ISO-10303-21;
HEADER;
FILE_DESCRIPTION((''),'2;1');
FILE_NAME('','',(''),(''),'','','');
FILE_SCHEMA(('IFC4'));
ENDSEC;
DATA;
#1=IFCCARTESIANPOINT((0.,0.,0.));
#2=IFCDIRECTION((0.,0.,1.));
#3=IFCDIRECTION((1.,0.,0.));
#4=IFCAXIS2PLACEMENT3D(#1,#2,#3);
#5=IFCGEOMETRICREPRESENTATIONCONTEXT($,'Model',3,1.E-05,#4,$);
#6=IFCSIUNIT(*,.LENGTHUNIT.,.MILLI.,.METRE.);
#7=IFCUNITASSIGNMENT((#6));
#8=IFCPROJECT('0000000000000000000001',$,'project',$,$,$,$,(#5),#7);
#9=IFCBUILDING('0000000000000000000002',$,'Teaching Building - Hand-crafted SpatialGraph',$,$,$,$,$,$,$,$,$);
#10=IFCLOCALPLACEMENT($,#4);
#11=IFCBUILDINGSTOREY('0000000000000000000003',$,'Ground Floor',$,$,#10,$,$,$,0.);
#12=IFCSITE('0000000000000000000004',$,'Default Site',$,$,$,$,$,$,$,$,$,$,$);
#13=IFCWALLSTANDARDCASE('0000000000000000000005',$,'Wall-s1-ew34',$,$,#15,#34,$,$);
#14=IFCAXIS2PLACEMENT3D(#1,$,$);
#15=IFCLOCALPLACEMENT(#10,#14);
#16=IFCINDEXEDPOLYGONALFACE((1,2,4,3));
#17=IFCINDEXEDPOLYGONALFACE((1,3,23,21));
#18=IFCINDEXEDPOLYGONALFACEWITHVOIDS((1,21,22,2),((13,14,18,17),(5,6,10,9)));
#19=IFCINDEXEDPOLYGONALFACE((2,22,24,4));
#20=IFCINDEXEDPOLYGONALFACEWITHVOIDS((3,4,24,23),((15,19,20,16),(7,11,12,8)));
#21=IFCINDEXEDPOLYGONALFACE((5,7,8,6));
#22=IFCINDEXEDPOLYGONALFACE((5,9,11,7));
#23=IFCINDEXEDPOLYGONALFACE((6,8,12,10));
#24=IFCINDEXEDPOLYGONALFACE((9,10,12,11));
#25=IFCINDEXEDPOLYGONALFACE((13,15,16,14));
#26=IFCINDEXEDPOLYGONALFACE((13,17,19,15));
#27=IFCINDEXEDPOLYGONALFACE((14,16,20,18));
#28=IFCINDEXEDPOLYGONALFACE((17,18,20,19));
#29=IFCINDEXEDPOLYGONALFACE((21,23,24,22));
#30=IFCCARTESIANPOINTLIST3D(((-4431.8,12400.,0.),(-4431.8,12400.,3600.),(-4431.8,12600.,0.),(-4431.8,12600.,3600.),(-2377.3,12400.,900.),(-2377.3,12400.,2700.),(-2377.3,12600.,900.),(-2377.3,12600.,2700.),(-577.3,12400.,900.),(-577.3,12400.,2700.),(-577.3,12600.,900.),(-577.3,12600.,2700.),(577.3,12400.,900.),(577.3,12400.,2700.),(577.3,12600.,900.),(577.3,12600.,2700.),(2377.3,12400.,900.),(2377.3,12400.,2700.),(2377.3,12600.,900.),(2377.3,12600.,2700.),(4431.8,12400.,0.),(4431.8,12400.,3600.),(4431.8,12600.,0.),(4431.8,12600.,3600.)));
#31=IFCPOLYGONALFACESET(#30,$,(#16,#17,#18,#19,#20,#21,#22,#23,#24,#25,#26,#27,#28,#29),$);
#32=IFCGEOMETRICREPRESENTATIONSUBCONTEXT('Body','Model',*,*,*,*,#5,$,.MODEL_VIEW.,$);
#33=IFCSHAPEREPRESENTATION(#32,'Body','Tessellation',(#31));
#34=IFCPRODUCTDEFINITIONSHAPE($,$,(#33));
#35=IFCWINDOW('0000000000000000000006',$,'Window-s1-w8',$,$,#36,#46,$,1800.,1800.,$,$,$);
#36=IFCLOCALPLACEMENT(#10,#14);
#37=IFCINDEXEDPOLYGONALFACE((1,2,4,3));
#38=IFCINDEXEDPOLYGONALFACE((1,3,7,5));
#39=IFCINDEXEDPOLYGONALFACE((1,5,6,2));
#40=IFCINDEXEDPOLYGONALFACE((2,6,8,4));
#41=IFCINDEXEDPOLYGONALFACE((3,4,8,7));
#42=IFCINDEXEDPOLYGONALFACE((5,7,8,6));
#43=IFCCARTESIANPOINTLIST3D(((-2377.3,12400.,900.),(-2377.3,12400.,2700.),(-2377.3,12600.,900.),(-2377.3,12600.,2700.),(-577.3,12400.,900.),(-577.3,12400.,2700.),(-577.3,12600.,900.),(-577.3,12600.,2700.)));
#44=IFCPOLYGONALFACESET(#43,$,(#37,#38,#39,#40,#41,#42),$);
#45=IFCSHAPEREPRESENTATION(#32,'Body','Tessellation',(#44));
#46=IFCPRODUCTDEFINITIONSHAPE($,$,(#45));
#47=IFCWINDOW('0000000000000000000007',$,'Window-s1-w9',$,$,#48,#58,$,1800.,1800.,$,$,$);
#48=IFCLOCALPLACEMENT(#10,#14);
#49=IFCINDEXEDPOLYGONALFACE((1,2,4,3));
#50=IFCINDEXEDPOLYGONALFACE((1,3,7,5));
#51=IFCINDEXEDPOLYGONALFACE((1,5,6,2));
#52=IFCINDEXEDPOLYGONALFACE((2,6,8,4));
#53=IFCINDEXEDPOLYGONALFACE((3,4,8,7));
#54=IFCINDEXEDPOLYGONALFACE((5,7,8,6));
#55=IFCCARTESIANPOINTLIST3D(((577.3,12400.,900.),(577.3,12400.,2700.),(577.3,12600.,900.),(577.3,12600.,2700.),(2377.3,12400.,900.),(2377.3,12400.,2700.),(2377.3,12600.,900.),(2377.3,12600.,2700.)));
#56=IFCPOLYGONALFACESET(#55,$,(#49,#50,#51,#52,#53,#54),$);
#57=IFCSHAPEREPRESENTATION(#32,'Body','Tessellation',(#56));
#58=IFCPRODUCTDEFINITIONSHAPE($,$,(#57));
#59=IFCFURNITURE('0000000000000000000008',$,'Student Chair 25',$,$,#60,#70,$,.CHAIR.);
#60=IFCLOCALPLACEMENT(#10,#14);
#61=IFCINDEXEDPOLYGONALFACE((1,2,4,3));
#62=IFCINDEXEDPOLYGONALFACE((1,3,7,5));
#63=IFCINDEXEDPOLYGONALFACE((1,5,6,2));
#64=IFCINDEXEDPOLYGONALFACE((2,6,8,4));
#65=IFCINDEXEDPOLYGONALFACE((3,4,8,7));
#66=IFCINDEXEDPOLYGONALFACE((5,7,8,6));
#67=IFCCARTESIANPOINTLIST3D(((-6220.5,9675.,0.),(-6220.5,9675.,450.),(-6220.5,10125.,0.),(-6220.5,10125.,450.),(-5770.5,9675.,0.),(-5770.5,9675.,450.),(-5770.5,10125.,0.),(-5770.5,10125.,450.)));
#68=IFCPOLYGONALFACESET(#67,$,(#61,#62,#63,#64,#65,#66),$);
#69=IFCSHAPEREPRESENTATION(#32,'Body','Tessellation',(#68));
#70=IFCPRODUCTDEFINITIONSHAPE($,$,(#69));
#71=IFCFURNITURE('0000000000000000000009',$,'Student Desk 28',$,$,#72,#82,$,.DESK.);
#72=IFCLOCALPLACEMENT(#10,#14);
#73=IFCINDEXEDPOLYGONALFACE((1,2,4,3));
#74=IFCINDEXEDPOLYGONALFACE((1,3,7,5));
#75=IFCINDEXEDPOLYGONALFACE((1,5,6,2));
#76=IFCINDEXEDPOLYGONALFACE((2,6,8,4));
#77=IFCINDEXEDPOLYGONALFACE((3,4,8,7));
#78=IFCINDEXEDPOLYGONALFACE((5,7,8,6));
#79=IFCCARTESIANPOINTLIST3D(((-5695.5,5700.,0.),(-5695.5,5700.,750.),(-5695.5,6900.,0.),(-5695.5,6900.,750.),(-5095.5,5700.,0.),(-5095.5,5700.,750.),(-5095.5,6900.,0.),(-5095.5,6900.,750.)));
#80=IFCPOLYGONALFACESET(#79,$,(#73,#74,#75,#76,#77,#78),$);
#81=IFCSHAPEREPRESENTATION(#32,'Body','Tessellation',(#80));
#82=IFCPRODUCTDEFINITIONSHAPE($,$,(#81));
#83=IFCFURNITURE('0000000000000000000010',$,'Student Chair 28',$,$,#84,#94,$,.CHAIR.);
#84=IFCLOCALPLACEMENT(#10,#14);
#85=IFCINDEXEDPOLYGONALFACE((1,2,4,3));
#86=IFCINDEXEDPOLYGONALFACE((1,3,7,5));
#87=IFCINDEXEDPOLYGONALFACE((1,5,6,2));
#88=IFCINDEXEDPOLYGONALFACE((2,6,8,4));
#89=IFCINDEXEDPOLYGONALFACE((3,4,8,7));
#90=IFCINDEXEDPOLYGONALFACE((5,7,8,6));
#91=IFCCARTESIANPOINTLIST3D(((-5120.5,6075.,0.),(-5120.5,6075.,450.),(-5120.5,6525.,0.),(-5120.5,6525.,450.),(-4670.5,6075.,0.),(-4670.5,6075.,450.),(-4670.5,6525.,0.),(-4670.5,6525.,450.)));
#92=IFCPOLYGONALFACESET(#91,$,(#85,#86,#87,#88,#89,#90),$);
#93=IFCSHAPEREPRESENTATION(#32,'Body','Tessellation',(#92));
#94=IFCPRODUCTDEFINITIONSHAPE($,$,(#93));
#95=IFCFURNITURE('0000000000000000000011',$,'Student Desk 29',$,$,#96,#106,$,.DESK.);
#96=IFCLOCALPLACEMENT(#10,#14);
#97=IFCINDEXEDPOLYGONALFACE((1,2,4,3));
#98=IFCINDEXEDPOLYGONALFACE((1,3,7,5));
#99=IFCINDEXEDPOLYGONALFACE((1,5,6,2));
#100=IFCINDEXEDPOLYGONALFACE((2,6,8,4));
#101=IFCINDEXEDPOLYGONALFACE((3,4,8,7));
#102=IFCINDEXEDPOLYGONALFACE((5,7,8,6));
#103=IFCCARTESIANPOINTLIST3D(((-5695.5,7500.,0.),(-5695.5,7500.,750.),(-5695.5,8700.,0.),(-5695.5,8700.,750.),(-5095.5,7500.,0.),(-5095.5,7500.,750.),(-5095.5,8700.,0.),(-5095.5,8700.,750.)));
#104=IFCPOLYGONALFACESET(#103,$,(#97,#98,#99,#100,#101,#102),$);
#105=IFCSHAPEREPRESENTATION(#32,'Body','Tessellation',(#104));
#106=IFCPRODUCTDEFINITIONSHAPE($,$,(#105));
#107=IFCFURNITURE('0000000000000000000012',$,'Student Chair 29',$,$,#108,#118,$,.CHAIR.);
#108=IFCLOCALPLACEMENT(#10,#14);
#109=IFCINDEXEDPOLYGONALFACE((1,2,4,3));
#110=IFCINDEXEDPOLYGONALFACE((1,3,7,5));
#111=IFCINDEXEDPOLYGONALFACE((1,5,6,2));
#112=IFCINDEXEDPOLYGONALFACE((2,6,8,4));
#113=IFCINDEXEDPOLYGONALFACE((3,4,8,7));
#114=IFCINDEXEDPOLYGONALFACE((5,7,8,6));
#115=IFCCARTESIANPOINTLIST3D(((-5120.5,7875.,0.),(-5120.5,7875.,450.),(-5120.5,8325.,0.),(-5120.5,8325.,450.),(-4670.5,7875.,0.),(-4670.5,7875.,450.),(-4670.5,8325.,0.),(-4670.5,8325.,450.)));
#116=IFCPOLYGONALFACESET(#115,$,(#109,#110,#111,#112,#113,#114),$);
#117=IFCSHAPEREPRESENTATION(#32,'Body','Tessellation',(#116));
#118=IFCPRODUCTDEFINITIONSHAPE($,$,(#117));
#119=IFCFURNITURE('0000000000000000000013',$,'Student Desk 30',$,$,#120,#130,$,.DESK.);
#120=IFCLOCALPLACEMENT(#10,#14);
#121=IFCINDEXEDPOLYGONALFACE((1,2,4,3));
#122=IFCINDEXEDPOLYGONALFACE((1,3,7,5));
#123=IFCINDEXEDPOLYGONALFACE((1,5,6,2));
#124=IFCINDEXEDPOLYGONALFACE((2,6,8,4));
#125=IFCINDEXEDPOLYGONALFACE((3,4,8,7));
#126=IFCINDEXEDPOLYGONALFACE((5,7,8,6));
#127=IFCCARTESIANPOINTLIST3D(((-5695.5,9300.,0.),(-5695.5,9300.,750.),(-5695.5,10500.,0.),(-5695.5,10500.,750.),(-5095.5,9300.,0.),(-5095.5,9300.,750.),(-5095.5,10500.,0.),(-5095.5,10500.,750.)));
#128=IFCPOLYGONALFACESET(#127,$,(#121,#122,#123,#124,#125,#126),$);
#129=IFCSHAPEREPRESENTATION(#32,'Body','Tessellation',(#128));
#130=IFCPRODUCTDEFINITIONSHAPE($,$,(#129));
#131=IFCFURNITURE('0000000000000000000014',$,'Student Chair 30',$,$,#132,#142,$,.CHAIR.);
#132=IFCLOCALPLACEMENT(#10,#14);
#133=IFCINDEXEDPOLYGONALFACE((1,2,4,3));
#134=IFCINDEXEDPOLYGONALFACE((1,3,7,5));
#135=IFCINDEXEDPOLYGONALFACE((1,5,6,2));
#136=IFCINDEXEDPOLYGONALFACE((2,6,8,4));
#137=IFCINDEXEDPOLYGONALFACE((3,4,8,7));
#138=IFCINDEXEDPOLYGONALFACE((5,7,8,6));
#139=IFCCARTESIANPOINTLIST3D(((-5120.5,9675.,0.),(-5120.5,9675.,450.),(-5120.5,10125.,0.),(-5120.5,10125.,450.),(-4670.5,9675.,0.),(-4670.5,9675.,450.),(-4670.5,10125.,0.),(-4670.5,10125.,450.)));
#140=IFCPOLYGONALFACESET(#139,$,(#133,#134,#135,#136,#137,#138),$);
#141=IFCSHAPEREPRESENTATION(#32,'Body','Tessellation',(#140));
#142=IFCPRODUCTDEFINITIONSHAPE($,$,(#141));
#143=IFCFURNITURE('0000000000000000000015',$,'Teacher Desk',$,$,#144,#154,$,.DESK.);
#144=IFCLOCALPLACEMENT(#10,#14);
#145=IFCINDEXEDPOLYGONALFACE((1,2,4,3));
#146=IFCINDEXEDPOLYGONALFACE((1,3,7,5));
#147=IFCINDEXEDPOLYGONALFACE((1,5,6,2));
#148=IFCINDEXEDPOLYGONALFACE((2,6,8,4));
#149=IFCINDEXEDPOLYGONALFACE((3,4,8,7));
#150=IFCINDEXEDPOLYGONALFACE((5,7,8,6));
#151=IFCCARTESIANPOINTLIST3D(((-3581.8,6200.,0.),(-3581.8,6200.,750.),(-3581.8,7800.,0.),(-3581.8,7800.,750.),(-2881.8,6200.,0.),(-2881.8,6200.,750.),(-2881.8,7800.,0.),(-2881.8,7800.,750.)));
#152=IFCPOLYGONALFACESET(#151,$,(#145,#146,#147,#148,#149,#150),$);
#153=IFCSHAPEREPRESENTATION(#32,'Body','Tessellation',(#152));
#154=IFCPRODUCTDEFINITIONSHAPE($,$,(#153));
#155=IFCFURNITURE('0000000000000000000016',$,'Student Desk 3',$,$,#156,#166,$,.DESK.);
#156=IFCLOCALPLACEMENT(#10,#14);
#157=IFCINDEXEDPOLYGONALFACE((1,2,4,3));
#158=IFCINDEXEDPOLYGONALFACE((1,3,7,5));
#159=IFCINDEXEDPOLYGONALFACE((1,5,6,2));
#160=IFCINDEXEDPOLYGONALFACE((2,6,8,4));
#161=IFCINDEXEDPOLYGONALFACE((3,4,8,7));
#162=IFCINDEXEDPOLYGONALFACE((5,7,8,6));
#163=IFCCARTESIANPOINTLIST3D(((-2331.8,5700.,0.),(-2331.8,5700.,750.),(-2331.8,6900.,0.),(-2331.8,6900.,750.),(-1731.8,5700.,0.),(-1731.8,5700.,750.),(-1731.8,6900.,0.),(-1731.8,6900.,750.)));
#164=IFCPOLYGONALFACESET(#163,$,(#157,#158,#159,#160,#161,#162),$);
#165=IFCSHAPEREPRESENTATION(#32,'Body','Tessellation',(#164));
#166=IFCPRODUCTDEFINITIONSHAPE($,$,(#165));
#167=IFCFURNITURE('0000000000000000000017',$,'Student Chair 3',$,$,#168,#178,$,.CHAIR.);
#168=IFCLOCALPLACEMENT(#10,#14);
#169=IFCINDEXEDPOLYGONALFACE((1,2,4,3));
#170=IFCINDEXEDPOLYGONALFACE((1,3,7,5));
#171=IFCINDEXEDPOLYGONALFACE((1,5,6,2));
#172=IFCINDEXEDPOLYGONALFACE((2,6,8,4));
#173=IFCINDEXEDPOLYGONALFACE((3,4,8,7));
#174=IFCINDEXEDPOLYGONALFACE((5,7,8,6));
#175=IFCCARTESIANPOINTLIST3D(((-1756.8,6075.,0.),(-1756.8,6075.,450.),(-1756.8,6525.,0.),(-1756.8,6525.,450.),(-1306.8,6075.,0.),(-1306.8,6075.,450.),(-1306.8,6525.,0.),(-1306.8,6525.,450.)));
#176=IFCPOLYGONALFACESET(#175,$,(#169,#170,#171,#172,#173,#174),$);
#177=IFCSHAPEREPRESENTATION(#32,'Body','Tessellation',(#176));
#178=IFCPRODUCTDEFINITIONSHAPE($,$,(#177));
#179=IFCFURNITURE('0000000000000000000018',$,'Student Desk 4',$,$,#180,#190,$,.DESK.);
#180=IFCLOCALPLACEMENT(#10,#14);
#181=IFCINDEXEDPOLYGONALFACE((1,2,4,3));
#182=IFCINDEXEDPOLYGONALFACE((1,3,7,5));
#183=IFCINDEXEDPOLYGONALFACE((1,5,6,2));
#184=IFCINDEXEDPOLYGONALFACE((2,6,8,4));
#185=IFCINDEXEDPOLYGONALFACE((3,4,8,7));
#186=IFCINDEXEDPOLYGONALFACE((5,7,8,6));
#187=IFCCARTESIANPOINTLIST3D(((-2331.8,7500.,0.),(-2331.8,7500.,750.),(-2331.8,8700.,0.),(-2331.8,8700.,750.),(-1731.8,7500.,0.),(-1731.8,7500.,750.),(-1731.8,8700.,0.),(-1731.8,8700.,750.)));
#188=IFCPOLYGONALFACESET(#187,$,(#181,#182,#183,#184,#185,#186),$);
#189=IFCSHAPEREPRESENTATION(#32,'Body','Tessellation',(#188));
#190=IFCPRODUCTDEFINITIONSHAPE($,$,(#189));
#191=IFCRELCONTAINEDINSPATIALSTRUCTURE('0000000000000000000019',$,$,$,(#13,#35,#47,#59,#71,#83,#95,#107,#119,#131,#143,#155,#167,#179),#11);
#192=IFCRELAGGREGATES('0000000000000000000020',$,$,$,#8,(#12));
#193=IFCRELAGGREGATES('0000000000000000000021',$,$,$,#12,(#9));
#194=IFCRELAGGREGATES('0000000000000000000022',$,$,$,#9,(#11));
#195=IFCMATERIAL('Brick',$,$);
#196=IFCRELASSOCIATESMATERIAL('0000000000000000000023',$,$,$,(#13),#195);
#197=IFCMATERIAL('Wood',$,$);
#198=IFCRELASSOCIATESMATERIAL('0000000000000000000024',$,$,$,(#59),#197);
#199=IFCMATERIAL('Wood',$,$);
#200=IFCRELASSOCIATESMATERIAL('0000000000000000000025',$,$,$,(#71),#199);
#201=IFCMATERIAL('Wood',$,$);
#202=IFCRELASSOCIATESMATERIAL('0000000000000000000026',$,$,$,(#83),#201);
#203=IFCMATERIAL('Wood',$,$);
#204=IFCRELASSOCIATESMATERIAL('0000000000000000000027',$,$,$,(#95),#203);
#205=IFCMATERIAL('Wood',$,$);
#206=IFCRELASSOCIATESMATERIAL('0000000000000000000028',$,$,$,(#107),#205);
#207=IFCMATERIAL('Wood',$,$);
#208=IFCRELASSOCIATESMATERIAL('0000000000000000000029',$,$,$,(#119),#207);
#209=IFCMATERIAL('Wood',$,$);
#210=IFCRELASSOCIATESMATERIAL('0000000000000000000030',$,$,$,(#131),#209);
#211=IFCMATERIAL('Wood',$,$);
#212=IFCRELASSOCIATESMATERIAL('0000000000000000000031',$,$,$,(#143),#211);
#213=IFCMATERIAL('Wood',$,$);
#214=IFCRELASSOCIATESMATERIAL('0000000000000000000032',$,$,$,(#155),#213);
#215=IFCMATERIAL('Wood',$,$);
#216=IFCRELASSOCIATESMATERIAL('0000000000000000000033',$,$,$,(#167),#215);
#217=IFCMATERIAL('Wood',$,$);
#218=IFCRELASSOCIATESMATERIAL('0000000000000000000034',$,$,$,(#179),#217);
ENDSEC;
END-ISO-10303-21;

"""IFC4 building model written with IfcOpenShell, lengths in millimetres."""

from ifc_helpers import new_model, si_unit, frame, frame_2d, origin_with_axes, origin_2d, place, context, subcontext, project, spatial, rectangle, extrude, material, element, fill, save


model = new_model("IFC4")

# Units and contexts
model_context = context("Model", 3, precision=1e-05, world=origin_with_axes())
body_context = subcontext(model_context, "Body", "Model", "MODEL_VIEW")
ifc_project = project(units=[si_unit("LENGTHUNIT", "METRE", prefix="MILLI")], contexts=[model_context])

# Site, building, storey
site = spatial("IfcSite", under=ifc_project, Name="Default Site")
building = spatial("IfcBuilding", under=site, Name="Teaching Building - Hand-crafted SpatialGraph")
storey_placement = place(None, origin_with_axes())
storey = spatial("IfcBuildingStorey", under=building, at=storey_placement, Name="Ground Floor", Elevation=0.0)

# Wall, openings, windows
ifc_material_1 = material(Name="Brick")
wall_placement = place(storey_placement, frame((-4431.8, 12500.0, 0.0), z_axis=(0.0, 0.0, 1.0), x_axis=(1.0, 0.0, 0.0)))
wall = element("IfcWallStandardCase", 1, at=wall_placement, inside=storey, material=ifc_material_1, Name="Wall-s1-ew34", context=body_context, shape_type="SweptSolid", body=[
    extrude(rectangle(XDim=8863.6, YDim=200.0, at=frame_2d((4431.8, 0.0))), origin_with_axes(), (0.0, 0.0, 1.0), 3600.0),
])
opening_1_placement = place(wall_placement, frame((2054.5, 0.0, 900.0), z_axis=(0.0, 0.0, 1.0), x_axis=(1.0, 0.0, 0.0)))
opening_1 = element("IfcOpeningElement", 2, at=opening_1_placement, cuts=wall, context=body_context, shape_type="SweptSolid", body=[
    extrude(rectangle(XDim=1800.0, YDim=400.0, at=frame_2d((900.0, 0.0))), origin_with_axes(), (0.0, 0.0, 1.0), 1800.0),
])
opening_2_placement = place(wall_placement, frame((5009.1, 0.0, 900.0), z_axis=(0.0, 0.0, 1.0), x_axis=(1.0, 0.0, 0.0)))
opening_2 = element("IfcOpeningElement", 3, at=opening_2_placement, cuts=wall, context=body_context, shape_type="SweptSolid", body=[
    extrude(rectangle(XDim=1800.0, YDim=400.0, at=frame_2d((900.0, 0.0))), origin_with_axes(), (0.0, 0.0, 1.0), 1800.0),
])
window_1_placement = place(storey_placement, frame((-2377.3, 12500.0, 900.0), z_axis=(0.0, 0.0, 1.0), x_axis=(1.0, 0.0, 0.0)))
window_1 = element("IfcWindow", 4, at=window_1_placement, inside=storey, Name="Window-s1-w8", OverallHeight=1800.0, OverallWidth=1800.0, context=body_context, shape_type="SweptSolid", body=[
    extrude(rectangle(XDim=1800.0, YDim=200.0, at=frame_2d((900.0, 0.0))), origin_with_axes(), (0.0, 0.0, 1.0), 1800.0),
])
fill(opening_1, window_1)
window_2_placement = place(storey_placement, frame((577.3, 12500.0, 900.0), z_axis=(0.0, 0.0, 1.0), x_axis=(1.0, 0.0, 0.0)))
window_2 = element("IfcWindow", 5, at=window_2_placement, inside=storey, Name="Window-s1-w9", OverallHeight=1800.0, OverallWidth=1800.0, context=body_context, shape_type="SweptSolid", body=[
    extrude(rectangle(XDim=1800.0, YDim=200.0, at=frame_2d((900.0, 0.0))), origin_with_axes(), (0.0, 0.0, 1.0), 1800.0),
])
fill(opening_2, window_2)

# Furniture
ifc_material_2 = material(Name="Wood")
furniture_1_placement = place(storey_placement, frame((-5995.5, 9900.0, 0.0), z_axis=(0.0, 0.0, 1.0), x_axis=(1.0, 0.0, 0.0)))
element("IfcFurniture", 6, at=furniture_1_placement, inside=storey, material=ifc_material_2, Name="Student Chair 25", PredefinedType="CHAIR", context=body_context, shape_type="SweptSolid", body=[
    extrude(rectangle(XDim=450.0, YDim=450.0, at=origin_2d()), origin_with_axes(), (0.0, 0.0, 1.0), 450.0),
])
ifc_material_3 = material(Name="Wood")
furniture_2_placement = place(storey_placement, frame((-5395.5, 6300.0, 0.0), z_axis=(0.0, 0.0, 1.0), x_axis=(0.0, 1.0, 0.0)))
element("IfcFurniture", 7, at=furniture_2_placement, inside=storey, material=ifc_material_3, Name="Student Desk 28", PredefinedType="DESK", context=body_context, shape_type="SweptSolid", body=[
    extrude(rectangle(XDim=1200.0, YDim=600.0, at=origin_2d()), origin_with_axes(), (0.0, 0.0, 1.0), 750.0),
])
ifc_material_4 = material(Name="Wood")
furniture_3_placement = place(storey_placement, frame((-4895.5, 6300.0, 0.0), z_axis=(0.0, 0.0, 1.0), x_axis=(1.0, 0.0, 0.0)))
element("IfcFurniture", 8, at=furniture_3_placement, inside=storey, material=ifc_material_4, Name="Student Chair 28", PredefinedType="CHAIR", context=body_context, shape_type="SweptSolid", body=[
    extrude(rectangle(XDim=450.0, YDim=450.0, at=origin_2d()), origin_with_axes(), (0.0, 0.0, 1.0), 450.0),
])
ifc_material_5 = material(Name="Wood")
furniture_4_placement = place(storey_placement, frame((-5395.5, 8100.0, 0.0), z_axis=(0.0, 0.0, 1.0), x_axis=(0.0, 1.0, 0.0)))
element("IfcFurniture", 9, at=furniture_4_placement, inside=storey, material=ifc_material_5, Name="Student Desk 29", PredefinedType="DESK", context=body_context, shape_type="SweptSolid", body=[
    extrude(rectangle(XDim=1200.0, YDim=600.0, at=origin_2d()), origin_with_axes(), (0.0, 0.0, 1.0), 750.0),
])
ifc_material_6 = material(Name="Wood")
furniture_5_placement = place(storey_placement, frame((-4895.5, 8100.0, 0.0), z_axis=(0.0, 0.0, 1.0), x_axis=(1.0, 0.0, 0.0)))
element("IfcFurniture", 10, at=furniture_5_placement, inside=storey, material=ifc_material_6, Name="Student Chair 29", PredefinedType="CHAIR", context=body_context, shape_type="SweptSolid", body=[
    extrude(rectangle(XDim=450.0, YDim=450.0, at=origin_2d()), origin_with_axes(), (0.0, 0.0, 1.0), 450.0),
])
ifc_material_7 = material(Name="Wood")
furniture_6_placement = place(storey_placement, frame((-5395.5, 9900.0, 0.0), z_axis=(0.0, 0.0, 1.0), x_axis=(0.0, 1.0, 0.0)))
element("IfcFurniture", 11, at=furniture_6_placement, inside=storey, material=ifc_material_7, Name="Student Desk 30", PredefinedType="DESK", context=body_context, shape_type="SweptSolid", body=[
    extrude(rectangle(XDim=1200.0, YDim=600.0, at=origin_2d()), origin_with_axes(), (0.0, 0.0, 1.0), 750.0),
])
ifc_material_8 = material(Name="Wood")
furniture_7_placement = place(storey_placement, frame((-4895.5, 9900.0, 0.0), z_axis=(0.0, 0.0, 1.0), x_axis=(1.0, 0.0, 0.0)))
element("IfcFurniture", 12, at=furniture_7_placement, inside=storey, material=ifc_material_8, Name="Student Chair 30", PredefinedType="CHAIR", context=body_context, shape_type="SweptSolid", body=[
    extrude(rectangle(XDim=450.0, YDim=450.0, at=origin_2d()), origin_with_axes(), (0.0, 0.0, 1.0), 450.0),
])
ifc_material_9 = material(Name="Wood")
furniture_8_placement = place(storey_placement, frame((-3231.8, 7000.0, 0.0), z_axis=(0.0, 0.0, 1.0), x_axis=(0.0, 1.0, 0.0)))
element("IfcFurniture", 13, at=furniture_8_placement, inside=storey, material=ifc_material_9, Name="Teacher Desk", PredefinedType="DESK", context=body_context, shape_type="SweptSolid", body=[
    extrude(rectangle(XDim=1600.0, YDim=700.0, at=origin_2d()), origin_with_axes(), (0.0, 0.0, 1.0), 750.0),
])
ifc_material_10 = material(Name="Wood")
furniture_9_placement = place(storey_placement, frame((-2031.8, 6300.0, 0.0), z_axis=(0.0, 0.0, 1.0), x_axis=(0.0, 1.0, 0.0)))
element("IfcFurniture", 14, at=furniture_9_placement, inside=storey, material=ifc_material_10, Name="Student Desk 3", PredefinedType="DESK", context=body_context, shape_type="SweptSolid", body=[
    extrude(rectangle(XDim=1200.0, YDim=600.0, at=origin_2d()), origin_with_axes(), (0.0, 0.0, 1.0), 750.0),
])
ifc_material_11 = material(Name="Wood")
furniture_10_placement = place(storey_placement, frame((-1531.8, 6300.0, 0.0), z_axis=(0.0, 0.0, 1.0), x_axis=(1.0, 0.0, 0.0)))
element("IfcFurniture", 15, at=furniture_10_placement, inside=storey, material=ifc_material_11, Name="Student Chair 3", PredefinedType="CHAIR", context=body_context, shape_type="SweptSolid", body=[
    extrude(rectangle(XDim=450.0, YDim=450.0, at=origin_2d()), origin_with_axes(), (0.0, 0.0, 1.0), 450.0),
])
ifc_material_12 = material(Name="Wood")
furniture_11_placement = place(storey_placement, frame((-2031.8, 8100.0, 0.0), z_axis=(0.0, 0.0, 1.0), x_axis=(0.0, 1.0, 0.0)))
element("IfcFurniture", 16, at=furniture_11_placement, inside=storey, material=ifc_material_12, Name="Student Desk 4", PredefinedType="DESK", context=body_context, shape_type="SweptSolid", body=[
    extrude(rectangle(XDim=1200.0, YDim=600.0, at=origin_2d()), origin_with_axes(), (0.0, 0.0, 1.0), 750.0),
])

save(model, "model.ifc")
